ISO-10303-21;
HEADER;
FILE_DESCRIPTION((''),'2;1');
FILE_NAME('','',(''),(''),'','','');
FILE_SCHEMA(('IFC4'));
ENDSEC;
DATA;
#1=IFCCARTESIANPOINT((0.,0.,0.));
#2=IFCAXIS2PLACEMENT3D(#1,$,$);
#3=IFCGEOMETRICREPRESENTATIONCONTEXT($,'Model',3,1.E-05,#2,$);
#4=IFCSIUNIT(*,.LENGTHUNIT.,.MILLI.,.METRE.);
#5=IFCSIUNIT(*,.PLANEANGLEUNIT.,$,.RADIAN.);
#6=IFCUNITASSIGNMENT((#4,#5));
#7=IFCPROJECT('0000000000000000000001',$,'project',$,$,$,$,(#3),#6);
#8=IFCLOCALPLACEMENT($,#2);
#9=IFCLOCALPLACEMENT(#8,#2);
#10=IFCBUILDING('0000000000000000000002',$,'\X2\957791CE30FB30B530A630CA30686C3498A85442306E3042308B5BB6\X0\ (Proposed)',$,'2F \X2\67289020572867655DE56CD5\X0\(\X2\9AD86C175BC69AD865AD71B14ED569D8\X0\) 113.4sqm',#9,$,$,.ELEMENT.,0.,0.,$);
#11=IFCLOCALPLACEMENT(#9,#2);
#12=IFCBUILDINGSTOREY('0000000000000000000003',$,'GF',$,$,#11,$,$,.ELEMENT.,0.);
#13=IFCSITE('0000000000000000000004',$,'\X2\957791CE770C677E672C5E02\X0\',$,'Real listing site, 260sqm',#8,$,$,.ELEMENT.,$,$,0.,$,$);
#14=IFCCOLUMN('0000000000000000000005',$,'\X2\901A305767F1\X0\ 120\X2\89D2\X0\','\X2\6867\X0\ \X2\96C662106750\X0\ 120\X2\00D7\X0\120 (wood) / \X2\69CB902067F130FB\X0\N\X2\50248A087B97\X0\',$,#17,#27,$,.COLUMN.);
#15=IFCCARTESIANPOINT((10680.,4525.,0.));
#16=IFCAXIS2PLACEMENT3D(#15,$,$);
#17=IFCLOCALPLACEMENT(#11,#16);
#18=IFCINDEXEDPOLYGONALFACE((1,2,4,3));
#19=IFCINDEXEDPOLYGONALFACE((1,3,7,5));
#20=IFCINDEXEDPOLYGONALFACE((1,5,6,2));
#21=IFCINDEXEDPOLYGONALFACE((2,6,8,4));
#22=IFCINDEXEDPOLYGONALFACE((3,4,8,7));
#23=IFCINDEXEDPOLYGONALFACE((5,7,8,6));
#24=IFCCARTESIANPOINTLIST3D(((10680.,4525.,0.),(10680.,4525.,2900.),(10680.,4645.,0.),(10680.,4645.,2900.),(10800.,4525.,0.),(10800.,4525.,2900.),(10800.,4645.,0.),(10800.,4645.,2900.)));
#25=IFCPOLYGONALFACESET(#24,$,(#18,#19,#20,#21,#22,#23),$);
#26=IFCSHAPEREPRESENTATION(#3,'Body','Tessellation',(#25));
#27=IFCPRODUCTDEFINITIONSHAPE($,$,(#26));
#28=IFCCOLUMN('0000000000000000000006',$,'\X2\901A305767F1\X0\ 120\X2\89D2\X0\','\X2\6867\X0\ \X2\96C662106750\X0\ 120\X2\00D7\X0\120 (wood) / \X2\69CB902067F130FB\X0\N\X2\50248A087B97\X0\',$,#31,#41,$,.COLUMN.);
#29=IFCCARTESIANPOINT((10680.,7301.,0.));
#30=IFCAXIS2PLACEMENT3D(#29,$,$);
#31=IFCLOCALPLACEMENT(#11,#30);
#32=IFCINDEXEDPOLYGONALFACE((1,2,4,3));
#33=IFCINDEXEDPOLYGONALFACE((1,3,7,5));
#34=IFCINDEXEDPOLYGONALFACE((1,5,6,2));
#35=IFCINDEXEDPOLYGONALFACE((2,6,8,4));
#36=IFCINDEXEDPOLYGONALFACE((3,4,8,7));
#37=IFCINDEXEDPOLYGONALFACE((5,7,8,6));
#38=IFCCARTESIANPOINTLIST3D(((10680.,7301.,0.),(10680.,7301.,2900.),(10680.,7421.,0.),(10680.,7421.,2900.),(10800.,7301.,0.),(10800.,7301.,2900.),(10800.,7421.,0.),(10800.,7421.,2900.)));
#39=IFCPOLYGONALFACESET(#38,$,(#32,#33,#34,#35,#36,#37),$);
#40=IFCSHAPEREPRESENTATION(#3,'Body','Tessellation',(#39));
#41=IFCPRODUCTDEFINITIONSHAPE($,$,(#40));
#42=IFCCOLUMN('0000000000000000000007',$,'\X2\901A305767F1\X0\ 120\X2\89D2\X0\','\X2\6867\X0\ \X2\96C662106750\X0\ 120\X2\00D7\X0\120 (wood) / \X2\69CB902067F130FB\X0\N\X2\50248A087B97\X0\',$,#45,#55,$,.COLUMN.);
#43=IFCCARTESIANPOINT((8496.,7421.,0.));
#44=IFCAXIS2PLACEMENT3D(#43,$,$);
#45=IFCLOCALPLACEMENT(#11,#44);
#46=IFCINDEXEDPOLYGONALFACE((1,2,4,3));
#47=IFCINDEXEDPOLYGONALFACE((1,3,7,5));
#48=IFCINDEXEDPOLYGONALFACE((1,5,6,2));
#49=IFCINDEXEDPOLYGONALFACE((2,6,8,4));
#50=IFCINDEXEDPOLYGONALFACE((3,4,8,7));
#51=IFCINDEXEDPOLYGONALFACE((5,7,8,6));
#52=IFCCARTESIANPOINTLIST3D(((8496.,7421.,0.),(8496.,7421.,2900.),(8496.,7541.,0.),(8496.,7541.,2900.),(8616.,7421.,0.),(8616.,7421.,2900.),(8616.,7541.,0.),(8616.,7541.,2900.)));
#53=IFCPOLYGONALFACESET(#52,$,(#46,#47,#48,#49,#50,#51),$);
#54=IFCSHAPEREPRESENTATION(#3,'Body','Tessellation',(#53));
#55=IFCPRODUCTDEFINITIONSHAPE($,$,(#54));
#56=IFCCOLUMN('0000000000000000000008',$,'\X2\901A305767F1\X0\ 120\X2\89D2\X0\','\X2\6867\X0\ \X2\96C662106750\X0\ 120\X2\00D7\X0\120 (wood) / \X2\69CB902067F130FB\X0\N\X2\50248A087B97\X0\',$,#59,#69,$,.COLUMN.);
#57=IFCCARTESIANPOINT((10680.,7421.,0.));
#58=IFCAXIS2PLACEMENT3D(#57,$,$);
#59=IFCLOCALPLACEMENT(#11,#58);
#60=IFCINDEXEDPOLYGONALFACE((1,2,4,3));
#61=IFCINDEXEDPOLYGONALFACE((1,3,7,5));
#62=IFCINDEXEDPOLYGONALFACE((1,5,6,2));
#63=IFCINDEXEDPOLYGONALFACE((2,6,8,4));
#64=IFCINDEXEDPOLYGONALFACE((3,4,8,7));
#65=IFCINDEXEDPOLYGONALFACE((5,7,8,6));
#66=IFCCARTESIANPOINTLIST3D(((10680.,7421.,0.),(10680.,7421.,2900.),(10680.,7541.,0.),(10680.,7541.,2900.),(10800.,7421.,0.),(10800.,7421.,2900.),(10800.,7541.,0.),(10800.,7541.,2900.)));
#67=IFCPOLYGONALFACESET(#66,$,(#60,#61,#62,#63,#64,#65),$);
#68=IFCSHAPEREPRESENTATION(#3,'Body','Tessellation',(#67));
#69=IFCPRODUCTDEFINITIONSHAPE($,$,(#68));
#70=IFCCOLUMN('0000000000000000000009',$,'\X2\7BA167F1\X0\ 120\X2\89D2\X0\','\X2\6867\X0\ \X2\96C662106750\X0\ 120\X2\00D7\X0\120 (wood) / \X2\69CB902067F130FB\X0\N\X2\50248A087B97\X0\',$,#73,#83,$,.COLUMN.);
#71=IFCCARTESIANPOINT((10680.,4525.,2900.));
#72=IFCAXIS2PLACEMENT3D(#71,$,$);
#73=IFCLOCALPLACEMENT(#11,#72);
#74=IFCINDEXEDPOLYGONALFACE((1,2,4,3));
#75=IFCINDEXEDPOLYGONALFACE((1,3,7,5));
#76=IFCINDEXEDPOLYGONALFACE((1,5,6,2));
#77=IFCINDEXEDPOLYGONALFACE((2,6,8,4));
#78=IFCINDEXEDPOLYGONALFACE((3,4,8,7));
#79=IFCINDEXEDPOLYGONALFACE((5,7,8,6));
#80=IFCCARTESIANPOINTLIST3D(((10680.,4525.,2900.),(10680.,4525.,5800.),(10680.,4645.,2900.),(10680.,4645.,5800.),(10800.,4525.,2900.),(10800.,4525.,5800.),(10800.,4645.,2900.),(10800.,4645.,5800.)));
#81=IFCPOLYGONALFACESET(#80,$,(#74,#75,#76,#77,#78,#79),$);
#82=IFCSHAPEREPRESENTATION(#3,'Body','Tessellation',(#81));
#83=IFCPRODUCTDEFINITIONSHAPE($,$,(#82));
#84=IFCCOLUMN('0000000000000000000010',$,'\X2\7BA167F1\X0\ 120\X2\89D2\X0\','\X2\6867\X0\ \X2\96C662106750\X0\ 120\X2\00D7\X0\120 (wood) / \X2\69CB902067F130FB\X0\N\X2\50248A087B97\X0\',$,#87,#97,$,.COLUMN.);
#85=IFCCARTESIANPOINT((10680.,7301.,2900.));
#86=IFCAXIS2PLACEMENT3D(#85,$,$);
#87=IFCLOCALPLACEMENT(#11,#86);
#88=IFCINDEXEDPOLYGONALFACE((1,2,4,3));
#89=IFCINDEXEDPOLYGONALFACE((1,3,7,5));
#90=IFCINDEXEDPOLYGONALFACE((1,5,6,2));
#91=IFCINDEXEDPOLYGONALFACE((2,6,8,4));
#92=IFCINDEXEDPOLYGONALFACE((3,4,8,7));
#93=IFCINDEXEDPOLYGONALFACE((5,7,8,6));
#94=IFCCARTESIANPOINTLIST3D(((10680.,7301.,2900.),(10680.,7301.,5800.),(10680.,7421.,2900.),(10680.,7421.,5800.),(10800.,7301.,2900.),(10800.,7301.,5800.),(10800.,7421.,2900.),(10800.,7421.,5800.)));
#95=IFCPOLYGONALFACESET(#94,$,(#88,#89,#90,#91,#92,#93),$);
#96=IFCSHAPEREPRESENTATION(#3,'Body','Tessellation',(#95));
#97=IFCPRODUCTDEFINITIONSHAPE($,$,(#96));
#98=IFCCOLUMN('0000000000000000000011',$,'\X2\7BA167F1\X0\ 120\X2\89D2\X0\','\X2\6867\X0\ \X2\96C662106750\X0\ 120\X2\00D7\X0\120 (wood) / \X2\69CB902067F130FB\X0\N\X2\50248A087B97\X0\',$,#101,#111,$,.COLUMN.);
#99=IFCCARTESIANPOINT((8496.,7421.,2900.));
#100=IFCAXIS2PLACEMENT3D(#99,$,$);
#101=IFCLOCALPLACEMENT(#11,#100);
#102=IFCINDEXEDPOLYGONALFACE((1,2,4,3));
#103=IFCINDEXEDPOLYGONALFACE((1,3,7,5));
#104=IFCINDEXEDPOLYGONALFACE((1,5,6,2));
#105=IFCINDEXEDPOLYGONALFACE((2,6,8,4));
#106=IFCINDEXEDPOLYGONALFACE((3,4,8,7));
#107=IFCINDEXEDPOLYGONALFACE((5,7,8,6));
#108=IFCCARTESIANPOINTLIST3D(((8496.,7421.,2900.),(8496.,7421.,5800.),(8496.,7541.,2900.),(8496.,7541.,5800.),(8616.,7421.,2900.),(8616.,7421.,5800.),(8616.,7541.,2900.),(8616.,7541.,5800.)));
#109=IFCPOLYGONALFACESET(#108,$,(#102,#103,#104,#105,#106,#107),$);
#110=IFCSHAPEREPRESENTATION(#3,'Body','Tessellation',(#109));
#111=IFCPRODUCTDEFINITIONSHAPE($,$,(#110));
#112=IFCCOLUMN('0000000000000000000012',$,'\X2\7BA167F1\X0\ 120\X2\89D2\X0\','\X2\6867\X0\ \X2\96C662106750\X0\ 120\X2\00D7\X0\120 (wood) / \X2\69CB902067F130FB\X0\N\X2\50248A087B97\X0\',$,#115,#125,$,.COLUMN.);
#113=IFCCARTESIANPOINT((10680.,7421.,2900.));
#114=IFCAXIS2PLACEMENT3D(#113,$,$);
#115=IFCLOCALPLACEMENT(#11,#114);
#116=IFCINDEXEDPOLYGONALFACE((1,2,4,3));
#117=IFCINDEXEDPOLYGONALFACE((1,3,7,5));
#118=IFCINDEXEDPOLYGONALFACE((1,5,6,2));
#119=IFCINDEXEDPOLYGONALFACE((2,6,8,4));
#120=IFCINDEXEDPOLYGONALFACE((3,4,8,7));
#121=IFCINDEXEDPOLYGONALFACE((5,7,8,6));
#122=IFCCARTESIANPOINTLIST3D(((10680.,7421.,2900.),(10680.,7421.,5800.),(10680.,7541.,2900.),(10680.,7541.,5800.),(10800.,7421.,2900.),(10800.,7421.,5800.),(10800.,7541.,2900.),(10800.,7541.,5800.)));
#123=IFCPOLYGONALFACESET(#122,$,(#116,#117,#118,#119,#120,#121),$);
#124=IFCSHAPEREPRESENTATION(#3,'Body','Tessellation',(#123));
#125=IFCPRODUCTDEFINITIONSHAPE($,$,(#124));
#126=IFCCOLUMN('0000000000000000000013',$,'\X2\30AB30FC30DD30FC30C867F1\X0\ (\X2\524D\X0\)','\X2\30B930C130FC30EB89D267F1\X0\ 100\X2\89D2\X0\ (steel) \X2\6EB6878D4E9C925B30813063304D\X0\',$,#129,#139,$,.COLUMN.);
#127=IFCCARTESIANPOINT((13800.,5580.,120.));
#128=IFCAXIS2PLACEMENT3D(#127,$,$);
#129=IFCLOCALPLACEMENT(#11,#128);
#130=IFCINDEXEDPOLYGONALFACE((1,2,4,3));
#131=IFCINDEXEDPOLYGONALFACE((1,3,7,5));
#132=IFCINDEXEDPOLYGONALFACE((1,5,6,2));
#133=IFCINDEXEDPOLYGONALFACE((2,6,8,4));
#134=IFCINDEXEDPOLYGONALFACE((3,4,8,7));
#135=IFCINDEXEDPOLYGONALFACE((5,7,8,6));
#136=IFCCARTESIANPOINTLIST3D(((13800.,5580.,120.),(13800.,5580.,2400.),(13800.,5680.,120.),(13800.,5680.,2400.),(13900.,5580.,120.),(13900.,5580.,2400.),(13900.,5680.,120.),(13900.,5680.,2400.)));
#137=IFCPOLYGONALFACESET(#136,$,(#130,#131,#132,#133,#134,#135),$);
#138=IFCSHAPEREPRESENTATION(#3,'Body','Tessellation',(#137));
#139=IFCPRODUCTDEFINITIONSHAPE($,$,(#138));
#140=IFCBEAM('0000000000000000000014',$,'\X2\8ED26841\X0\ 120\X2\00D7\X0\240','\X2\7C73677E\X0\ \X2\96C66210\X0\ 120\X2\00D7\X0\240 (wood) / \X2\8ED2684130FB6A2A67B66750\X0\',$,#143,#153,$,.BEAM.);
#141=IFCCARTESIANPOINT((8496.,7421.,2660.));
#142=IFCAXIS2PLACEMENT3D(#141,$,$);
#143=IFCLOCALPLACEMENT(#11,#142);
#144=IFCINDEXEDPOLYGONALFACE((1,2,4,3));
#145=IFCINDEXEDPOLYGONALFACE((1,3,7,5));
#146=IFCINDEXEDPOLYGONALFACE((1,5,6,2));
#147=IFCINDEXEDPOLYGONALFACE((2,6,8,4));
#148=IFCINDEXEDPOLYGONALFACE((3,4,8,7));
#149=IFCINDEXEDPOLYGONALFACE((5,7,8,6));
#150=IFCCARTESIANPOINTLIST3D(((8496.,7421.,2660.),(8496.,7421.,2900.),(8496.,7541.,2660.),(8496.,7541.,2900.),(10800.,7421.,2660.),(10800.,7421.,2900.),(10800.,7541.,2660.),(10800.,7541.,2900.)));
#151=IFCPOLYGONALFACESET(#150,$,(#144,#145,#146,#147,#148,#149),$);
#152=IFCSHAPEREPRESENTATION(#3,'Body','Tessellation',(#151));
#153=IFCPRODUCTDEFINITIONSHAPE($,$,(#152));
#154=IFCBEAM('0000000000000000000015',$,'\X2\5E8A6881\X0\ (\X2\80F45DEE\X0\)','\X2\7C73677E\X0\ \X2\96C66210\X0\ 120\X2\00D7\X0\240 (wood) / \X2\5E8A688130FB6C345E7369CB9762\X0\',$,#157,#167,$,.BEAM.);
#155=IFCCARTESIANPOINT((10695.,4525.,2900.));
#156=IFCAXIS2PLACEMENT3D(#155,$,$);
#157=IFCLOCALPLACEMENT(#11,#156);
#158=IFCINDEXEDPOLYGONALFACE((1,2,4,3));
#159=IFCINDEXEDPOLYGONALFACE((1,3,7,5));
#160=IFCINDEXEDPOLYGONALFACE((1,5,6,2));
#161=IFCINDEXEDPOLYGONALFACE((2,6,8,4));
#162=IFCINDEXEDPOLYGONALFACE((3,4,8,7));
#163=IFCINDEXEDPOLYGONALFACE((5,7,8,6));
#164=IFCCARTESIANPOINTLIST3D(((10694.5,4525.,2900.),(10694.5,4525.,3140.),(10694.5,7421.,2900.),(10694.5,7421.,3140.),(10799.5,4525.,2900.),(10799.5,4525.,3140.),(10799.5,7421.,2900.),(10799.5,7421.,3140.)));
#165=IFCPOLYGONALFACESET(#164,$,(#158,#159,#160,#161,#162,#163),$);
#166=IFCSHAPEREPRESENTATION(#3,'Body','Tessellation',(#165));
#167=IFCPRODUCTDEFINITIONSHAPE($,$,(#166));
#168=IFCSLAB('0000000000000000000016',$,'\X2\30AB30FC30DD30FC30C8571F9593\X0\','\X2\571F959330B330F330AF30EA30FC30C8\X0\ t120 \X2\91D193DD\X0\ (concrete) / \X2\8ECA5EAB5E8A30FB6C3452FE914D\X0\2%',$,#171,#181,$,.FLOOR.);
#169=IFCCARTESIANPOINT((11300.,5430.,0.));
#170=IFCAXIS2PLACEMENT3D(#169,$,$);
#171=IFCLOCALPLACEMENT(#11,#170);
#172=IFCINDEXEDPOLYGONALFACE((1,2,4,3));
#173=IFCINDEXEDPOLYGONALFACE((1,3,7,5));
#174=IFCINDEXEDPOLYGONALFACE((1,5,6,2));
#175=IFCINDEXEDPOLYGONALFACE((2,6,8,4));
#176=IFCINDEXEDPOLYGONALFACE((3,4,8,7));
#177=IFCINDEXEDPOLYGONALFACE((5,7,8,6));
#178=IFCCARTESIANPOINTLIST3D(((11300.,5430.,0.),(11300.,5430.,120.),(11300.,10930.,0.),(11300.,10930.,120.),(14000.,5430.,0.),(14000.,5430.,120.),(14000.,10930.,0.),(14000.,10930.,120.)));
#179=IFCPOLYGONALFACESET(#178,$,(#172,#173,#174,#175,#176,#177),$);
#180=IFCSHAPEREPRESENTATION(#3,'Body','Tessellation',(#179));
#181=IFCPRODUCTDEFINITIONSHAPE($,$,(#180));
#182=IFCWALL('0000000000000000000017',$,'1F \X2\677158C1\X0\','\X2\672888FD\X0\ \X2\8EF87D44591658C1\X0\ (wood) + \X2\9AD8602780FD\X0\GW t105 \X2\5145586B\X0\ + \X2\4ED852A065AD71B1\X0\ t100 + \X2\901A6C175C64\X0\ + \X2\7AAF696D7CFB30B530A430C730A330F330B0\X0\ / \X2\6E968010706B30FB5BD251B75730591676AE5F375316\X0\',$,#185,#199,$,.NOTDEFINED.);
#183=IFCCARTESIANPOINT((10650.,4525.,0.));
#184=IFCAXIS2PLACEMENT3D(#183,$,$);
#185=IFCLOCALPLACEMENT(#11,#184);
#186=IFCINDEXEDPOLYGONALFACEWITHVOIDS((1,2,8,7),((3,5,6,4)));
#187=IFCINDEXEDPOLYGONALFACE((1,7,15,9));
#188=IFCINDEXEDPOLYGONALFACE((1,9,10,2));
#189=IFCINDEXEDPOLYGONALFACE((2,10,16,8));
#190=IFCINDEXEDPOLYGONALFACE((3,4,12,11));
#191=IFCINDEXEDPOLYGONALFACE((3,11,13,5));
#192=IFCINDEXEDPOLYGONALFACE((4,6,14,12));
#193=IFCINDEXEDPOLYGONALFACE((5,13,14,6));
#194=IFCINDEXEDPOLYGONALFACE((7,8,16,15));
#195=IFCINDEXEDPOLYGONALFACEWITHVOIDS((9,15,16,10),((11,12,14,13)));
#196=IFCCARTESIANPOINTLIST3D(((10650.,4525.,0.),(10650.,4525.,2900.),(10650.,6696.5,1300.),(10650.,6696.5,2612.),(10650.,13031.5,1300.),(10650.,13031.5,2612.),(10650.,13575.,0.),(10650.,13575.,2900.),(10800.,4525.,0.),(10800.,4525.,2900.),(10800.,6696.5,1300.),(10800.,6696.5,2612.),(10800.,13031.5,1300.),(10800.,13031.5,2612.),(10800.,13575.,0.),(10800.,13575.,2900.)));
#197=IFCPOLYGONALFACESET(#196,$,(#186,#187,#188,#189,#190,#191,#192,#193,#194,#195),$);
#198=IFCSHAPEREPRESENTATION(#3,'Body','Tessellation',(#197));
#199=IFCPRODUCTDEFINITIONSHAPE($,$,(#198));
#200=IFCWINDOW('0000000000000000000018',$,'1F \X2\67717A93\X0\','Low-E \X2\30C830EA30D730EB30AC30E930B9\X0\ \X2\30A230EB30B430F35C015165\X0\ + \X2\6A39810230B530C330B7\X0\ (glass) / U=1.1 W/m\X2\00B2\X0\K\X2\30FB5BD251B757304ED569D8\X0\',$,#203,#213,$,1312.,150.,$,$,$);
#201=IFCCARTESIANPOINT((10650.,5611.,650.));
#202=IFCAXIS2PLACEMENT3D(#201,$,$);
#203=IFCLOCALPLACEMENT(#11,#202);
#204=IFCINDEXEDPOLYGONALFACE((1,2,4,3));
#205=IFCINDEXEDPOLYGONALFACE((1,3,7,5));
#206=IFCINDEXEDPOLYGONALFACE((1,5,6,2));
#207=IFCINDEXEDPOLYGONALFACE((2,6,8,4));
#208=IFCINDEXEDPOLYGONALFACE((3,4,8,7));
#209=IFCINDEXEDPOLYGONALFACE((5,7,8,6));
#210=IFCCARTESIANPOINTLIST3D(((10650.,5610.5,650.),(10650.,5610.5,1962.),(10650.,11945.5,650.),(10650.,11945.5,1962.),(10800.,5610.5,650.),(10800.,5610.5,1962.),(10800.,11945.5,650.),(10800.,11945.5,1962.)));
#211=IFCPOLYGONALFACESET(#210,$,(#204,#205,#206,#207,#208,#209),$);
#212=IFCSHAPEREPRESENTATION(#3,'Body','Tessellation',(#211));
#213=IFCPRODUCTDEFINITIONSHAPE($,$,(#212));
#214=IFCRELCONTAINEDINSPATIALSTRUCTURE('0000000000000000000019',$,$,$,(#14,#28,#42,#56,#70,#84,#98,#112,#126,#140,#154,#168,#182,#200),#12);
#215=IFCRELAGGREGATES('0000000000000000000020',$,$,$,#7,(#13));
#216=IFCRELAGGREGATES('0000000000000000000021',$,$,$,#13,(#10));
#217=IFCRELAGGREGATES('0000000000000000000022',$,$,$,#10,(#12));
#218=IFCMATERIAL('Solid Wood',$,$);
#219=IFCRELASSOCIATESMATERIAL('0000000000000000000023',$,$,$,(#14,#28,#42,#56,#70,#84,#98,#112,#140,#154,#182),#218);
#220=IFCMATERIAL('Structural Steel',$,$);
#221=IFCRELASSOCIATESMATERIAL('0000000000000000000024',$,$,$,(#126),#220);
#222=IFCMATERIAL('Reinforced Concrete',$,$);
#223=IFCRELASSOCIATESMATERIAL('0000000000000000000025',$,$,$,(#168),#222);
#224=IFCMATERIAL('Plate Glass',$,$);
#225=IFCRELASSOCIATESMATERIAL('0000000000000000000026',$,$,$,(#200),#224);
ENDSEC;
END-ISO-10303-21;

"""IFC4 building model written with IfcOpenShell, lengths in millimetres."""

from ifc_helpers import new_model, si_unit, frame, frame_2d, origin, place, context, project, spatial, rectangle, extrude, material, element, fill, save


model = new_model("IFC4")

# Units and contexts
model_context = context("Model", 3, precision=1e-05, world=origin())
ifc_project = project(units=[si_unit("LENGTHUNIT", "METRE", prefix="MILLI"), si_unit("PLANEANGLEUNIT", "RADIAN")], contexts=[model_context])

# Site, building, storey
site_placement = place(None, origin())
site = spatial("IfcSite", under=ifc_project, at=site_placement, Name="長野県松本市", ObjectType="Real listing site, 260sqm", CompositionType="ELEMENT", RefElevation=0.0)
building_placement = place(site_placement, origin())
building = spatial("IfcBuilding", under=site, at=building_placement, Name="長野・サウナと水風呂のある家 (Proposed)", ObjectType="2F 木造在来工法(高気密高断熱仕様) 113.4sqm", CompositionType="ELEMENT", ElevationOfRefHeight=0.0, ElevationOfTerrain=0.0)
storey_placement = place(building_placement, origin())
storey = spatial("IfcBuildingStorey", under=building, at=storey_placement, Name="GF", CompositionType="ELEMENT", Elevation=0.0)

# Columns
ifc_material_1 = material(Name="Solid Wood")
column_1_placement = place(storey_placement, frame((10680.0, 4525.0, 0.0)))
element("IfcColumn", 1, at=column_1_placement, inside=storey, material=ifc_material_1, Name="通し柱 120角", Description="桧 集成材 120×120 (wood) / 構造柱・N値計算", PredefinedType="COLUMN", context=model_context, shape_type="SweptSolid", body=[
    extrude(rectangle(XDim=120.0, YDim=120.0, at=frame_2d((60.0, 60.0))), frame((10680.0, 4525.0, 0.0)), (0.0, 0.0, 1.0), 2900.0),
])
column_2_placement = place(storey_placement, frame((10680.0, 7301.0, 0.0)))
element("IfcColumn", 2, at=column_2_placement, inside=storey, material=ifc_material_1, Name="通し柱 120角", Description="桧 集成材 120×120 (wood) / 構造柱・N値計算", PredefinedType="COLUMN", context=model_context, shape_type="SweptSolid", body=[
    extrude(rectangle(XDim=120.0, YDim=120.0, at=frame_2d((60.0, 60.0))), frame((10680.0, 7301.0, 0.0)), (0.0, 0.0, 1.0), 2900.0),
])
column_3_placement = place(storey_placement, frame((8496.0, 7421.0, 0.0)))
element("IfcColumn", 3, at=column_3_placement, inside=storey, material=ifc_material_1, Name="通し柱 120角", Description="桧 集成材 120×120 (wood) / 構造柱・N値計算", PredefinedType="COLUMN", context=model_context, shape_type="SweptSolid", body=[
    extrude(rectangle(XDim=120.0, YDim=120.0, at=frame_2d((60.0, 60.0))), frame((8496.0, 7421.0, 0.0)), (0.0, 0.0, 1.0), 2900.0),
])
column_4_placement = place(storey_placement, frame((10680.0, 7421.0, 0.0)))
element("IfcColumn", 4, at=column_4_placement, inside=storey, material=ifc_material_1, Name="通し柱 120角", Description="桧 集成材 120×120 (wood) / 構造柱・N値計算", PredefinedType="COLUMN", context=model_context, shape_type="SweptSolid", body=[
    extrude(rectangle(XDim=120.0, YDim=120.0, at=frame_2d((60.0, 60.0))), frame((10680.0, 7421.0, 0.0)), (0.0, 0.0, 1.0), 2900.0),
])
column_5_placement = place(storey_placement, frame((10680.0, 4525.0, 2900.0)))
element("IfcColumn", 5, at=column_5_placement, inside=storey, material=ifc_material_1, Name="管柱 120角", Description="桧 集成材 120×120 (wood) / 構造柱・N値計算", PredefinedType="COLUMN", context=model_context, shape_type="SweptSolid", body=[
    extrude(rectangle(XDim=120.0, YDim=120.0, at=frame_2d((60.0, 60.0))), frame((10680.0, 4525.0, 2900.0)), (0.0, 0.0, 1.0), 2900.0),
])
column_6_placement = place(storey_placement, frame((10680.0, 7301.0, 2900.0)))
element("IfcColumn", 6, at=column_6_placement, inside=storey, material=ifc_material_1, Name="管柱 120角", Description="桧 集成材 120×120 (wood) / 構造柱・N値計算", PredefinedType="COLUMN", context=model_context, shape_type="SweptSolid", body=[
    extrude(rectangle(XDim=120.0, YDim=120.0, at=frame_2d((60.0, 60.0))), frame((10680.0, 7301.0, 2900.0)), (0.0, 0.0, 1.0), 2900.0),
])
column_7_placement = place(storey_placement, frame((8496.0, 7421.0, 2900.0)))
element("IfcColumn", 7, at=column_7_placement, inside=storey, material=ifc_material_1, Name="管柱 120角", Description="桧 集成材 120×120 (wood) / 構造柱・N値計算", PredefinedType="COLUMN", context=model_context, shape_type="SweptSolid", body=[
    extrude(rectangle(XDim=120.0, YDim=120.0, at=frame_2d((60.0, 60.0))), frame((8496.0, 7421.0, 2900.0)), (0.0, 0.0, 1.0), 2900.0),
])
column_8_placement = place(storey_placement, frame((10680.0, 7421.0, 2900.0)))
element("IfcColumn", 8, at=column_8_placement, inside=storey, material=ifc_material_1, Name="管柱 120角", Description="桧 集成材 120×120 (wood) / 構造柱・N値計算", PredefinedType="COLUMN", context=model_context, shape_type="SweptSolid", body=[
    extrude(rectangle(XDim=120.0, YDim=120.0, at=frame_2d((60.0, 60.0))), frame((10680.0, 7421.0, 2900.0)), (0.0, 0.0, 1.0), 2900.0),
])
ifc_material_2 = material(Name="Structural Steel")
column_9_placement = place(storey_placement, frame((13800.0, 5580.0, 120.0)))
element("IfcColumn", 9, at=column_9_placement, inside=storey, material=ifc_material_2, Name="カーポート柱 (前)", Description="スチール角柱 100角 (steel) 溶融亜鉛めっき", PredefinedType="COLUMN", context=model_context, shape_type="SweptSolid", body=[
    extrude(rectangle(XDim=100.0, YDim=100.0, at=frame_2d((50.0, 50.0))), frame((13800.0, 5580.0, 120.0)), (0.0, 0.0, 1.0), 2280.0),
])

# Beams
beam_1_placement = place(storey_placement, frame((8496.0, 7421.0, 2660.0)))
element("IfcBeam", 10, at=beam_1_placement, inside=storey, material=ifc_material_1, Name="軒桁 120×240", Description="米松 集成 120×240 (wood) / 軒桁・横架材", PredefinedType="BEAM", context=model_context, shape_type="SweptSolid", body=[
    extrude(rectangle(XDim=2304.0, YDim=120.0, at=frame_2d((1152.0, 60.0))), frame((8496.0, 7421.0, 2660.0)), (0.0, 0.0, 1.0), 240.0),
])
beam_2_placement = place(storey_placement, frame((10695.0, 4525.0, 2900.0)))
element("IfcBeam", 11, at=beam_2_placement, inside=storey, material=ifc_material_1, Name="床梁 (胴差)", Description="米松 集成 120×240 (wood) / 床梁・水平構面", PredefinedType="BEAM", context=model_context, shape_type="SweptSolid", body=[
    extrude(rectangle(XDim=105.0, YDim=2896.0, at=frame_2d((52.0, 1448.0))), frame((10695.0, 4525.0, 2900.0)), (0.0, 0.0, 1.0), 240.0),
])

# Slab
ifc_material_3 = material(Name="Reinforced Concrete")
slab_placement = place(storey_placement, frame((11300.0, 5430.0, 0.0)))
element("IfcSlab", 12, at=slab_placement, inside=storey, material=ifc_material_3, Name="カーポート土間", Description="土間コンクリート t120 金鏝 (concrete) / 車庫床・水勾配2%", PredefinedType="FLOOR", context=model_context, shape_type="SweptSolid", body=[
    extrude(rectangle(XDim=2700.0, YDim=5500.0, at=frame_2d((1350.0, 2750.0))), frame((11300.0, 5430.0, 0.0)), (0.0, 0.0, 1.0), 120.0),
])

# Wall, opening, window
wall_1_placement = place(storey_placement, frame((10650.0, 4525.0, 0.0)))
wall_1 = element("IfcWall", 13, at=wall_1_placement, inside=storey, material=ifc_material_1, Name="1F 東壁", Description="木製 軸組外壁 (wood) + 高性能GW t105 充填 + 付加断熱 t100 + 通気層 + 窯業系サイディング / 準耐火・寒冷地外皮強化", PredefinedType="NOTDEFINED", context=model_context, shape_type="SweptSolid", body=[
    extrude(rectangle(XDim=150.0, YDim=9050.0, at=frame_2d((75.0, 4525.0))), frame((10650.0, 4525.0, 0.0)), (0.0, 0.0, 1.0), 2900.0),
])
opening_1_placement = place(storey_placement, frame((10650.0, 5611.0, 650.0)))
opening_1 = element("IfcOpeningElement", 14, at=opening_1_placement, cuts=wall_1, PredefinedType="NOTDEFINED", context=model_context, shape_type="SweptSolid", body=[
    extrude(rectangle(XDim=150.0, YDim=6335.0, at=frame_2d((75.0, 3167.0))), frame((10650.0, 5611.0, 650.0)), (0.0, 0.0, 1.0), 1312.0),
])
ifc_material_4 = material(Name="Plate Glass")
window_1_placement = place(storey_placement, frame((10650.0, 5611.0, 650.0)))
window_1 = element("IfcWindow", 15, at=window_1_placement, inside=storey, material=ifc_material_4, Name="1F 東窓", Description="Low-E トリプルガラス アルゴン封入 + 樹脂サッシ (glass) / U=1.1 W/m²K・寒冷地仕様", OverallHeight=1312.0, OverallWidth=150.0, context=model_context, shape_type="SweptSolid", body=[
    extrude(rectangle(XDim=150.0, YDim=6335.0, at=frame_2d((75.0, 3167.0))), frame((10650.0, 5611.0, 650.0)), (0.0, 0.0, 1.0), 1312.0),
])
fill(opening_1, window_1)

save(model, "model.ifc")
